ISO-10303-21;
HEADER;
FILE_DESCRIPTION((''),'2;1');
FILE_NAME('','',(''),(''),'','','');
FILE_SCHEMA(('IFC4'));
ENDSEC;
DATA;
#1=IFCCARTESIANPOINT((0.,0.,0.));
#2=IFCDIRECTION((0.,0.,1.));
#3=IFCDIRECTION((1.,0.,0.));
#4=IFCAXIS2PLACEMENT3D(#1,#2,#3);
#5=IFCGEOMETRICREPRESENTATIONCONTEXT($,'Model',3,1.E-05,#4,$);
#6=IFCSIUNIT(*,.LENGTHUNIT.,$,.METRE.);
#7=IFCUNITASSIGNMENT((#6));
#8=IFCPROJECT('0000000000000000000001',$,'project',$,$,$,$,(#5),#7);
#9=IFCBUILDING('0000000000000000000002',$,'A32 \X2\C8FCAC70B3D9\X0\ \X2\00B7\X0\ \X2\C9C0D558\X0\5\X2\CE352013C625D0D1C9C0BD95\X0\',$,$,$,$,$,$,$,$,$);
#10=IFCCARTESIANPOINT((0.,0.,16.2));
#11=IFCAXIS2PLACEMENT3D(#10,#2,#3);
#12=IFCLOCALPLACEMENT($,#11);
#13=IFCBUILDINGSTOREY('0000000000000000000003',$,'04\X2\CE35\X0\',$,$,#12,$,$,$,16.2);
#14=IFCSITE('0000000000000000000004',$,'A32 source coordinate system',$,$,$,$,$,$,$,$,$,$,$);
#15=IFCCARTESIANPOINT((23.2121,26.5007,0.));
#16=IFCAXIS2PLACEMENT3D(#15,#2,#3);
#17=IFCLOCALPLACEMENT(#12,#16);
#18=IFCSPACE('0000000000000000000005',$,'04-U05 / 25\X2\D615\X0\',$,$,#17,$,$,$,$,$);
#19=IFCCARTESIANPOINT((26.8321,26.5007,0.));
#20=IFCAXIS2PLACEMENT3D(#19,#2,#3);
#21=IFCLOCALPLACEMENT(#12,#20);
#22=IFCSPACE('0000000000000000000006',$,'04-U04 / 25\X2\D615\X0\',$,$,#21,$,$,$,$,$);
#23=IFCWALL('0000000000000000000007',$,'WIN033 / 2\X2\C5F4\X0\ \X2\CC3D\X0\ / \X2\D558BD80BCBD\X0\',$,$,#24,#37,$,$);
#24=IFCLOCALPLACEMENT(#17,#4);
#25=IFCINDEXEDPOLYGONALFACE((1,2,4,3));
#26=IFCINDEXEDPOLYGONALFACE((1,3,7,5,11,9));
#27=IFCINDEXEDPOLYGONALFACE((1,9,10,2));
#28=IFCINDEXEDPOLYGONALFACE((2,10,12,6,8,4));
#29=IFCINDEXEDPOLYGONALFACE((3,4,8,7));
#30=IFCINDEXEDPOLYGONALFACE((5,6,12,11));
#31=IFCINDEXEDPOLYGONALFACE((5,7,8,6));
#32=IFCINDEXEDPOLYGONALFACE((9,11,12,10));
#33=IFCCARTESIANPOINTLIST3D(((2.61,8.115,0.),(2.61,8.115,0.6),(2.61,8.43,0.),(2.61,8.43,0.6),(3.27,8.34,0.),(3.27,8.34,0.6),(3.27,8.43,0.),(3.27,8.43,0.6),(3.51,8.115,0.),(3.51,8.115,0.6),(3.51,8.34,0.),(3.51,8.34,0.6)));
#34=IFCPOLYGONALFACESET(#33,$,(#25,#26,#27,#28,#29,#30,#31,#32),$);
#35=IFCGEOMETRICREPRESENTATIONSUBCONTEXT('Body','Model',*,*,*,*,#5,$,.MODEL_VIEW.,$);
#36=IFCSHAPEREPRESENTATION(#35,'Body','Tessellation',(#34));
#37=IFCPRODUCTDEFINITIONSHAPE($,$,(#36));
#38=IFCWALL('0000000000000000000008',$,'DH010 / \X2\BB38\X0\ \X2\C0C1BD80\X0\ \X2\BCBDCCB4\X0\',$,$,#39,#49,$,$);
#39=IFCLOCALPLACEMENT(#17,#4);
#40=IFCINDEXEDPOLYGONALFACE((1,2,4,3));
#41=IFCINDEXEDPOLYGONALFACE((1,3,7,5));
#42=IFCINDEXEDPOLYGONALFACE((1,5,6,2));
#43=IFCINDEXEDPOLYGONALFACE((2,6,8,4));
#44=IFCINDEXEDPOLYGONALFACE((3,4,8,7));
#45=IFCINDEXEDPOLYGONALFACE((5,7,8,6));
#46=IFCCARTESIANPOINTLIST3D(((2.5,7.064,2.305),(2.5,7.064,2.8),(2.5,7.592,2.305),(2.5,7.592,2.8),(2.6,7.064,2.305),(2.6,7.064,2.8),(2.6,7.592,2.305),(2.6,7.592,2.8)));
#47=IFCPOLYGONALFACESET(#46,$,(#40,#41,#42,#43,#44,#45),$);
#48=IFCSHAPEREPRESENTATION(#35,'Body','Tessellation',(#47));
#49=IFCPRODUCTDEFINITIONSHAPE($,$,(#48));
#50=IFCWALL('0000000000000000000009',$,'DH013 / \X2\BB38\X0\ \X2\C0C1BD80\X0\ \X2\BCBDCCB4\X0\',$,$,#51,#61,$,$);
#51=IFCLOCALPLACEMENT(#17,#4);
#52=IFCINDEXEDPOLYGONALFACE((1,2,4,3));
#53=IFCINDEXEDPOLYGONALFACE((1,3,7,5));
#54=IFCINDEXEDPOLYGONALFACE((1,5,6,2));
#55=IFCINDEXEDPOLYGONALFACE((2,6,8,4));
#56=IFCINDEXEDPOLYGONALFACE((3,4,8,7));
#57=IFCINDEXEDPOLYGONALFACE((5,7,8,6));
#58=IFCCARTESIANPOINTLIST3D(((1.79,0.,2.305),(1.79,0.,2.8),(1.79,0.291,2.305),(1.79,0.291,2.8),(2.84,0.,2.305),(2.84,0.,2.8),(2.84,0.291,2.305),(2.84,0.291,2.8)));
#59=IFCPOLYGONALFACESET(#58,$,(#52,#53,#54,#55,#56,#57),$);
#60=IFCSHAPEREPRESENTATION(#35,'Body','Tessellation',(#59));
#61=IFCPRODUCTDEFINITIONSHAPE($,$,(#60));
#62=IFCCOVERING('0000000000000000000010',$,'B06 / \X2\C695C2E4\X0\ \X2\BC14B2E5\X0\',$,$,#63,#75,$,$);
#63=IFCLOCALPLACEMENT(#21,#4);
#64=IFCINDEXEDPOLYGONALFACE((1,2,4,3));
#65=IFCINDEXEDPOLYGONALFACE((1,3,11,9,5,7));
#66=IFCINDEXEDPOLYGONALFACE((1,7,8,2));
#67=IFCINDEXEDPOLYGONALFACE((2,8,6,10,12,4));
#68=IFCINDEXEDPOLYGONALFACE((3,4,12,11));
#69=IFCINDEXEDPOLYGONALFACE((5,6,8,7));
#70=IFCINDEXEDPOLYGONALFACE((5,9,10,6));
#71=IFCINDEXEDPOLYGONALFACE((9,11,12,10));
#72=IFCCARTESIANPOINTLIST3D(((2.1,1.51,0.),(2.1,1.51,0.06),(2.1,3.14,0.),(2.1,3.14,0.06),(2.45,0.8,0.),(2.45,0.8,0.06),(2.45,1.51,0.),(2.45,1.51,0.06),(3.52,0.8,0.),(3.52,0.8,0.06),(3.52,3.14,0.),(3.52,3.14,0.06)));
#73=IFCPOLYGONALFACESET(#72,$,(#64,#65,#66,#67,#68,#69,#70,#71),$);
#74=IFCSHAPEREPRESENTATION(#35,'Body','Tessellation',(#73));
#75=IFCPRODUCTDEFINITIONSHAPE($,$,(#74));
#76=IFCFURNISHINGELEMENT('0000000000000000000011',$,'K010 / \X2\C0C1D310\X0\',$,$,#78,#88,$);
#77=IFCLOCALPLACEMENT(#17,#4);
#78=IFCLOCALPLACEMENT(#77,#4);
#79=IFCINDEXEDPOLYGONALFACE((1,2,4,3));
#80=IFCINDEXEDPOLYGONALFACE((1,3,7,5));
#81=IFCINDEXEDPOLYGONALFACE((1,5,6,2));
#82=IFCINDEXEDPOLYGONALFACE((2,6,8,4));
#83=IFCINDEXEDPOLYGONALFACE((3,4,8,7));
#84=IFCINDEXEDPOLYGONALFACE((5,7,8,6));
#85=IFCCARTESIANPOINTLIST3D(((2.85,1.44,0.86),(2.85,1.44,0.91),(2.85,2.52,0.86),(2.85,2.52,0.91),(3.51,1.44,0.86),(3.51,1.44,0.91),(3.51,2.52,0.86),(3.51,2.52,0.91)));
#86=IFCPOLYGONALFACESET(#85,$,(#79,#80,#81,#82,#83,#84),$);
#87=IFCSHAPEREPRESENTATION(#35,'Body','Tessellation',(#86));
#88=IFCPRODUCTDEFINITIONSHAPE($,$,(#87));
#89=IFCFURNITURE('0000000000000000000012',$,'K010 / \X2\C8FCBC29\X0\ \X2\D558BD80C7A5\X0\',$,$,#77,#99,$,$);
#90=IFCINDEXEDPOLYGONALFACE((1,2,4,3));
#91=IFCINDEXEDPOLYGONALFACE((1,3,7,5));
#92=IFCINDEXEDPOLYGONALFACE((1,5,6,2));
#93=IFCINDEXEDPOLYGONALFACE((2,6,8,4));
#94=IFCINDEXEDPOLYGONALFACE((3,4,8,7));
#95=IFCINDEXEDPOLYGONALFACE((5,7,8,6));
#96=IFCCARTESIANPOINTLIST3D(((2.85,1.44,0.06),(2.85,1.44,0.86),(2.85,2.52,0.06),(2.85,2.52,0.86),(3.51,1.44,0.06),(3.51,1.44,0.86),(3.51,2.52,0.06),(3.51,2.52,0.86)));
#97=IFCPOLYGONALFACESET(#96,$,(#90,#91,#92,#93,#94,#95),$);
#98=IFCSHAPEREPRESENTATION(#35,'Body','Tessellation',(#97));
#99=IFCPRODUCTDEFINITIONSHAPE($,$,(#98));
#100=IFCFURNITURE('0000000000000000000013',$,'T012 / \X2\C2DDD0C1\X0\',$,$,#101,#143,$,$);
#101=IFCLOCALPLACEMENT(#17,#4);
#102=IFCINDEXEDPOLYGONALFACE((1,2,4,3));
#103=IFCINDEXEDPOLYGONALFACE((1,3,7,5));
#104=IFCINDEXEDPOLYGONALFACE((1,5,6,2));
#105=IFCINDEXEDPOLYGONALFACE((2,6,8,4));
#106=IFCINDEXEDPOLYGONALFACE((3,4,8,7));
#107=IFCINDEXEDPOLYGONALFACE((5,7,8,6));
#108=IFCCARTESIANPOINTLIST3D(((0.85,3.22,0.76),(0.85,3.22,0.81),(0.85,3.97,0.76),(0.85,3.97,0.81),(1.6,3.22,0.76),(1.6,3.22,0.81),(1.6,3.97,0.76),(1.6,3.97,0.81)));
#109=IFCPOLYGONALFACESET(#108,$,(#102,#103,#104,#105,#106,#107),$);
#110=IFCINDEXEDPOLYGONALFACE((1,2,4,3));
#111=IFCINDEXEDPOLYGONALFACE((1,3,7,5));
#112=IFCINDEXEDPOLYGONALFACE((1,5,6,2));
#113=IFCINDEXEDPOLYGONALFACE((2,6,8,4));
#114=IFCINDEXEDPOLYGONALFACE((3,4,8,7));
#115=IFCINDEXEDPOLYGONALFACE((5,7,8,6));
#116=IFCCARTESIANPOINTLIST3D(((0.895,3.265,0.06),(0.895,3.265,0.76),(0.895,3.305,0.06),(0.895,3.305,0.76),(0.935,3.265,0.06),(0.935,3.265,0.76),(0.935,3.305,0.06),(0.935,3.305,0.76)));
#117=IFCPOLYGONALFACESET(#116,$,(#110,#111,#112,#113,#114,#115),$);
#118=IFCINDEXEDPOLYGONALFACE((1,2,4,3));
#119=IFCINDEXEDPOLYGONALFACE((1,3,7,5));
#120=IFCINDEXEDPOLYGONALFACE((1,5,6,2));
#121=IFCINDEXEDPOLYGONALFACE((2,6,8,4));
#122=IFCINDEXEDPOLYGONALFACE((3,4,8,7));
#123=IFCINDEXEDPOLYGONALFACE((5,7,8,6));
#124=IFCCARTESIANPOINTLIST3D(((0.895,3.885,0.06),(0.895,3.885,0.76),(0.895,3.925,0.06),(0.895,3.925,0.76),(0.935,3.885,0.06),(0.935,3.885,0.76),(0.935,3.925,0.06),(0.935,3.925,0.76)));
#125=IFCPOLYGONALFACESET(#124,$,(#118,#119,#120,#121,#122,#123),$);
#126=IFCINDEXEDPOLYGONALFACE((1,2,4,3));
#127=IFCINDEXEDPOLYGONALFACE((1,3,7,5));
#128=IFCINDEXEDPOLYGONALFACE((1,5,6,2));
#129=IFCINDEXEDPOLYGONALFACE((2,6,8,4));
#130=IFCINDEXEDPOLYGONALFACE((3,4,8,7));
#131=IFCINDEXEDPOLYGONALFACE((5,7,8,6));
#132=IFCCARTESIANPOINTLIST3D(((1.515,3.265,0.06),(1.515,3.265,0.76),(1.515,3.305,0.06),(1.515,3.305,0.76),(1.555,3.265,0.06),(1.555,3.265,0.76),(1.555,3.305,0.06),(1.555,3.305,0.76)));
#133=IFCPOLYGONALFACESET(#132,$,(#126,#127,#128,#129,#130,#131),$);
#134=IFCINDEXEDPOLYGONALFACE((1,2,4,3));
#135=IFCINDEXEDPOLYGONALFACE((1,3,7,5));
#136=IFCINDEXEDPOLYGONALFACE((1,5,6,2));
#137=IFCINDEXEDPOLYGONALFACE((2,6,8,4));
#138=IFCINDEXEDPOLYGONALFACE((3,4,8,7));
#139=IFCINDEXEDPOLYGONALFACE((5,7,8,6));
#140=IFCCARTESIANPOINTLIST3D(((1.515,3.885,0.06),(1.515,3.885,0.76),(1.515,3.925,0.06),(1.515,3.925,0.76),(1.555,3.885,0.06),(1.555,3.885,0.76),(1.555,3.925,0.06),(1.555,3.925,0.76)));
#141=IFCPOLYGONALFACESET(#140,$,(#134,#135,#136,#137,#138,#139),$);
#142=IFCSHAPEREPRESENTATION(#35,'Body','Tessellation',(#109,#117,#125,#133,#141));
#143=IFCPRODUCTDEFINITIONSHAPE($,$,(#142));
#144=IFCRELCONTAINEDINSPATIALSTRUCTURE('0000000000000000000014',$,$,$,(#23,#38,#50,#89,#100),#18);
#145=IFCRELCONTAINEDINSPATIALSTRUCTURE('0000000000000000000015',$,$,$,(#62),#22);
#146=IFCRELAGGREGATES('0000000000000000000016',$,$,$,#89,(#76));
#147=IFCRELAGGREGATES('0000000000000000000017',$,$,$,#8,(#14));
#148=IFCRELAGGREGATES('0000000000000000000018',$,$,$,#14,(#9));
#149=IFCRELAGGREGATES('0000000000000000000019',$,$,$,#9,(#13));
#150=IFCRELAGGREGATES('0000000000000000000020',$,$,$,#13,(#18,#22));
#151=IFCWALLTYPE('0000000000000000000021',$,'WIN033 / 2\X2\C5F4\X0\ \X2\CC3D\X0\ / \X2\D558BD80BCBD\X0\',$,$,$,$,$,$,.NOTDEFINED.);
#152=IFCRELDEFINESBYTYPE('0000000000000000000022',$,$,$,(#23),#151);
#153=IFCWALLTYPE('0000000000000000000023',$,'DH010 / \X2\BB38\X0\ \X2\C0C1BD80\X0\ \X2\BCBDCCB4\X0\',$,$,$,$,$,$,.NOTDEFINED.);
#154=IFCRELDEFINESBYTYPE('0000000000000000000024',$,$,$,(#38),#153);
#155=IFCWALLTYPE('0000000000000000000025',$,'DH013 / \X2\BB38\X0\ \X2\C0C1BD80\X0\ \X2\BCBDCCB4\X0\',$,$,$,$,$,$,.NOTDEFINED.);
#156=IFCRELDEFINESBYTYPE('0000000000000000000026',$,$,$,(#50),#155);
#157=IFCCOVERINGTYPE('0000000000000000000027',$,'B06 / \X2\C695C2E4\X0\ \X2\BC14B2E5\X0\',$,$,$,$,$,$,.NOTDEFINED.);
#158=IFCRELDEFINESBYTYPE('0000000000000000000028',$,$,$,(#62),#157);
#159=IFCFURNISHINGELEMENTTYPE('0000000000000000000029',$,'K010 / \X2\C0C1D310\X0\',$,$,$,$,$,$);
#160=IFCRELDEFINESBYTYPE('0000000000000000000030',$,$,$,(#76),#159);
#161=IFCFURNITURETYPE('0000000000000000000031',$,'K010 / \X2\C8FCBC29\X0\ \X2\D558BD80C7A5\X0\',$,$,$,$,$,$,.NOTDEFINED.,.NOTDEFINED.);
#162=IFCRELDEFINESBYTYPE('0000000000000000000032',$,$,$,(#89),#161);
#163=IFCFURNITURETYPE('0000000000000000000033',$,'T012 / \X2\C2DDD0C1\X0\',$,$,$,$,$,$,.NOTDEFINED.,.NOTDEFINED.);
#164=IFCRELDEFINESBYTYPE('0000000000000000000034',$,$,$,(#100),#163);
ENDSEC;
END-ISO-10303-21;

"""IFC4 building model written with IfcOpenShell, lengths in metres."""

from ifc_helpers import new_model, si_unit, frame, origin, origin_with_axes, place, context, subcontext, project, spatial, polyline, outline, extrude, source, transform, mapped, type_object, type_shapes, element, aggregate, save


model = new_model("IFC4")

# Units and contexts
model_context = context("Model", 3, precision=1e-05, world=origin_with_axes())
body_context = subcontext(model_context, "Body", "Model", "MODEL_VIEW")
ifc_project = project(units=[si_unit("LENGTHUNIT", "METRE")], contexts=[model_context])

# Site, building, storey, space
site = spatial("IfcSite", under=ifc_project, Name="A32 source coordinate system")
building = spatial("IfcBuilding", under=site, Name="A32 주거동 · 지하5층–옥탑지붕")
storey_placement = place(None, frame((0.0, 0.0, 16.2), z_axis=(0.0, 0.0, 1.0), x_axis=(1.0, 0.0, 0.0)))
storey = spatial("IfcBuildingStorey", under=building, at=storey_placement, Name="04층", Elevation=16.2)
space_1_placement = place(storey_placement, frame((23.2121, 26.5007, 0.0), z_axis=(0.0, 0.0, 1.0), x_axis=(1.0, 0.0, 0.0)))
space_1 = spatial("IfcSpace", under=storey, at=space_1_placement, Name="04-U05 / 25형")

# Walls
wall_type_1 = type_object("IfcWallType", Name="WIN033 / 2열 창 / 하부벽", PredefinedType="NOTDEFINED")
shared_shape_1 = source(origin(), body_context, "Body", "SweptSolid", [
    extrude(outline(polyline([(2.61, 8.43), (3.27, 8.43), (3.27, 8.34), (3.51, 8.34), (3.51, 8.115), (2.61, 8.115), (2.61, 8.43)])), origin(), (0.0, 0.0, 1.0), 0.6),
])
type_shapes(wall_type_1, [shared_shape_1])
wall_1_placement = place(space_1_placement, origin_with_axes())
element("IfcWall", 1, at=wall_1_placement, inside=space_1, type_object=wall_type_1, Name="WIN033 / 2열 창 / 하부벽", context=body_context, shape_type="MappedRepresentation", body=[
    mapped(shared_shape_1, transform((0.0, 0.0, 0.0), scale=1.0)),
])
wall_type_2 = type_object("IfcWallType", Name="DH010 / 문 상부 벽체", PredefinedType="NOTDEFINED")
shared_shape_2 = source(origin(), body_context, "Body", "SweptSolid", [
    extrude(outline(polyline([(2.5, 7.592), (2.6, 7.592), (2.6, 7.064), (2.5, 7.064), (2.5, 7.592)])), frame((0.0, 0.0, 2.305)), (0.0, 0.0, 1.0), 0.495),
])
type_shapes(wall_type_2, [shared_shape_2])
wall_2_placement = place(space_1_placement, origin_with_axes())
element("IfcWall", 2, at=wall_2_placement, inside=space_1, type_object=wall_type_2, Name="DH010 / 문 상부 벽체", context=body_context, shape_type="MappedRepresentation", body=[
    mapped(shared_shape_2, transform((0.0, 0.0, 0.0), scale=1.0)),
])
wall_type_3 = type_object("IfcWallType", Name="DH013 / 문 상부 벽체", PredefinedType="NOTDEFINED")
shared_shape_3 = source(origin(), body_context, "Body", "SweptSolid", [
    extrude(outline(polyline([(2.84, 0.291), (2.84, 0.0), (1.79, 0.0), (1.79, 0.291), (2.84, 0.291)])), frame((0.0, 0.0, 2.305)), (0.0, 0.0, 1.0), 0.495),
])
type_shapes(wall_type_3, [shared_shape_3])
wall_3_placement = place(space_1_placement, origin_with_axes())
element("IfcWall", 3, at=wall_3_placement, inside=space_1, type_object=wall_type_3, Name="DH013 / 문 상부 벽체", context=body_context, shape_type="MappedRepresentation", body=[
    mapped(shared_shape_3, transform((0.0, 0.0, 0.0), scale=1.0)),
])

# Shared definitions
space_2_placement = place(storey_placement, frame((26.8321, 26.5007, 0.0), z_axis=(0.0, 0.0, 1.0), x_axis=(1.0, 0.0, 0.0)))
space_2 = spatial("IfcSpace", under=storey, at=space_2_placement, Name="04-U04 / 25형")

# Covering
covering_type_1 = type_object("IfcCoveringType", Name="B06 / 욕실 바닥", PredefinedType="NOTDEFINED")
shared_shape_4 = source(origin(), body_context, "Body", "SweptSolid", [
    extrude(outline(polyline([(2.1, 3.14), (3.52, 3.14), (3.52, 0.8), (2.45, 0.8), (2.45, 1.51), (2.1, 1.51), (2.1, 3.14)])), origin(), (0.0, 0.0, 1.0), 0.06),
])
type_shapes(covering_type_1, [shared_shape_4])
covering_1_placement = place(space_2_placement, origin_with_axes())
element("IfcCovering", 4, at=covering_1_placement, inside=space_2, type_object=covering_type_1, Name="B06 / 욕실 바닥", context=body_context, shape_type="MappedRepresentation", body=[
    mapped(shared_shape_4, transform((0.0, 0.0, 0.0), scale=1.0)),
])

# Furnishing element
furnishing_element_type_1 = type_object("IfcFurnishingElementType", Name="K010 / 상판")
shared_shape_5 = source(origin(), body_context, "Body", "SweptSolid", [
    extrude(outline(polyline([(2.85, 2.52), (3.51, 2.52), (3.51, 1.44), (2.85, 1.44), (2.85, 2.52)])), frame((0.0, 0.0, 0.86)), (0.0, 0.0, 1.0), 0.05),
])
type_shapes(furnishing_element_type_1, [shared_shape_5])
furniture_1_placement = place(space_1_placement, origin_with_axes())
furnishing_1_placement = place(furniture_1_placement, origin_with_axes())
furnishing_1 = element("IfcFurnishingElement", 5, at=furnishing_1_placement, type_object=furnishing_element_type_1, Name="K010 / 상판", context=body_context, shape_type="MappedRepresentation", body=[
    mapped(shared_shape_5, transform((0.0, 0.0, 0.0), scale=1.0)),
])

# Furniture
furniture_type_1 = type_object("IfcFurnitureType", Name="K010 / 주방 하부장", AssemblyPlace="NOTDEFINED", PredefinedType="NOTDEFINED")
shared_shape_6 = source(origin(), body_context, "Body", "SweptSolid", [
    extrude(outline(polyline([(2.85, 1.44), (2.85, 2.52), (3.51, 2.52), (3.51, 1.44), (2.85, 1.44)])), frame((0.0, 0.0, 0.06)), (0.0, 0.0, 1.0), 0.8),
])
type_shapes(furniture_type_1, [shared_shape_6])
furniture_1 = element("IfcFurniture", 6, at=furniture_1_placement, inside=space_1, type_object=furniture_type_1, Name="K010 / 주방 하부장", context=body_context, shape_type="MappedRepresentation", body=[
    mapped(shared_shape_6, transform((0.0, 0.0, 0.0), scale=1.0)),
])
aggregate(furniture_1, [furnishing_1])
furniture_type_2 = type_object("IfcFurnitureType", Name="T012 / 식탁", AssemblyPlace="NOTDEFINED", PredefinedType="NOTDEFINED")
shared_shape_7 = source(origin(), body_context, "Body", "SweptSolid", [
    extrude(outline(polyline([(1.6, 3.97), (1.6, 3.22), (0.85, 3.22), (0.85, 3.97), (1.6, 3.97)])), frame((0.0, 0.0, 0.76)), (0.0, 0.0, 1.0), 0.05),
    extrude(outline(polyline([(0.895, 3.265), (0.895, 3.305), (0.935, 3.305), (0.935, 3.265), (0.895, 3.265)])), frame((0.0, 0.0, 0.06)), (0.0, 0.0, 1.0), 0.7),
    extrude(outline(polyline([(0.895, 3.885), (0.895, 3.925), (0.935, 3.925), (0.935, 3.885), (0.895, 3.885)])), frame((0.0, 0.0, 0.06)), (0.0, 0.0, 1.0), 0.7),
    extrude(outline(polyline([(1.515, 3.265), (1.515, 3.305), (1.555, 3.305), (1.555, 3.265), (1.515, 3.265)])), frame((0.0, 0.0, 0.06)), (0.0, 0.0, 1.0), 0.7),
    extrude(outline(polyline([(1.515, 3.885), (1.515, 3.925), (1.555, 3.925), (1.555, 3.885), (1.515, 3.885)])), frame((0.0, 0.0, 0.06)), (0.0, 0.0, 1.0), 0.7),
])
type_shapes(furniture_type_2, [shared_shape_7])
furniture_2_placement = place(space_1_placement, origin_with_axes())
element("IfcFurniture", 7, at=furniture_2_placement, inside=space_1, type_object=furniture_type_2, Name="T012 / 식탁", context=body_context, shape_type="MappedRepresentation", body=[
    mapped(shared_shape_7, transform((0.0, 0.0, 0.0), scale=1.0)),
])

save(model, "model.ifc")
